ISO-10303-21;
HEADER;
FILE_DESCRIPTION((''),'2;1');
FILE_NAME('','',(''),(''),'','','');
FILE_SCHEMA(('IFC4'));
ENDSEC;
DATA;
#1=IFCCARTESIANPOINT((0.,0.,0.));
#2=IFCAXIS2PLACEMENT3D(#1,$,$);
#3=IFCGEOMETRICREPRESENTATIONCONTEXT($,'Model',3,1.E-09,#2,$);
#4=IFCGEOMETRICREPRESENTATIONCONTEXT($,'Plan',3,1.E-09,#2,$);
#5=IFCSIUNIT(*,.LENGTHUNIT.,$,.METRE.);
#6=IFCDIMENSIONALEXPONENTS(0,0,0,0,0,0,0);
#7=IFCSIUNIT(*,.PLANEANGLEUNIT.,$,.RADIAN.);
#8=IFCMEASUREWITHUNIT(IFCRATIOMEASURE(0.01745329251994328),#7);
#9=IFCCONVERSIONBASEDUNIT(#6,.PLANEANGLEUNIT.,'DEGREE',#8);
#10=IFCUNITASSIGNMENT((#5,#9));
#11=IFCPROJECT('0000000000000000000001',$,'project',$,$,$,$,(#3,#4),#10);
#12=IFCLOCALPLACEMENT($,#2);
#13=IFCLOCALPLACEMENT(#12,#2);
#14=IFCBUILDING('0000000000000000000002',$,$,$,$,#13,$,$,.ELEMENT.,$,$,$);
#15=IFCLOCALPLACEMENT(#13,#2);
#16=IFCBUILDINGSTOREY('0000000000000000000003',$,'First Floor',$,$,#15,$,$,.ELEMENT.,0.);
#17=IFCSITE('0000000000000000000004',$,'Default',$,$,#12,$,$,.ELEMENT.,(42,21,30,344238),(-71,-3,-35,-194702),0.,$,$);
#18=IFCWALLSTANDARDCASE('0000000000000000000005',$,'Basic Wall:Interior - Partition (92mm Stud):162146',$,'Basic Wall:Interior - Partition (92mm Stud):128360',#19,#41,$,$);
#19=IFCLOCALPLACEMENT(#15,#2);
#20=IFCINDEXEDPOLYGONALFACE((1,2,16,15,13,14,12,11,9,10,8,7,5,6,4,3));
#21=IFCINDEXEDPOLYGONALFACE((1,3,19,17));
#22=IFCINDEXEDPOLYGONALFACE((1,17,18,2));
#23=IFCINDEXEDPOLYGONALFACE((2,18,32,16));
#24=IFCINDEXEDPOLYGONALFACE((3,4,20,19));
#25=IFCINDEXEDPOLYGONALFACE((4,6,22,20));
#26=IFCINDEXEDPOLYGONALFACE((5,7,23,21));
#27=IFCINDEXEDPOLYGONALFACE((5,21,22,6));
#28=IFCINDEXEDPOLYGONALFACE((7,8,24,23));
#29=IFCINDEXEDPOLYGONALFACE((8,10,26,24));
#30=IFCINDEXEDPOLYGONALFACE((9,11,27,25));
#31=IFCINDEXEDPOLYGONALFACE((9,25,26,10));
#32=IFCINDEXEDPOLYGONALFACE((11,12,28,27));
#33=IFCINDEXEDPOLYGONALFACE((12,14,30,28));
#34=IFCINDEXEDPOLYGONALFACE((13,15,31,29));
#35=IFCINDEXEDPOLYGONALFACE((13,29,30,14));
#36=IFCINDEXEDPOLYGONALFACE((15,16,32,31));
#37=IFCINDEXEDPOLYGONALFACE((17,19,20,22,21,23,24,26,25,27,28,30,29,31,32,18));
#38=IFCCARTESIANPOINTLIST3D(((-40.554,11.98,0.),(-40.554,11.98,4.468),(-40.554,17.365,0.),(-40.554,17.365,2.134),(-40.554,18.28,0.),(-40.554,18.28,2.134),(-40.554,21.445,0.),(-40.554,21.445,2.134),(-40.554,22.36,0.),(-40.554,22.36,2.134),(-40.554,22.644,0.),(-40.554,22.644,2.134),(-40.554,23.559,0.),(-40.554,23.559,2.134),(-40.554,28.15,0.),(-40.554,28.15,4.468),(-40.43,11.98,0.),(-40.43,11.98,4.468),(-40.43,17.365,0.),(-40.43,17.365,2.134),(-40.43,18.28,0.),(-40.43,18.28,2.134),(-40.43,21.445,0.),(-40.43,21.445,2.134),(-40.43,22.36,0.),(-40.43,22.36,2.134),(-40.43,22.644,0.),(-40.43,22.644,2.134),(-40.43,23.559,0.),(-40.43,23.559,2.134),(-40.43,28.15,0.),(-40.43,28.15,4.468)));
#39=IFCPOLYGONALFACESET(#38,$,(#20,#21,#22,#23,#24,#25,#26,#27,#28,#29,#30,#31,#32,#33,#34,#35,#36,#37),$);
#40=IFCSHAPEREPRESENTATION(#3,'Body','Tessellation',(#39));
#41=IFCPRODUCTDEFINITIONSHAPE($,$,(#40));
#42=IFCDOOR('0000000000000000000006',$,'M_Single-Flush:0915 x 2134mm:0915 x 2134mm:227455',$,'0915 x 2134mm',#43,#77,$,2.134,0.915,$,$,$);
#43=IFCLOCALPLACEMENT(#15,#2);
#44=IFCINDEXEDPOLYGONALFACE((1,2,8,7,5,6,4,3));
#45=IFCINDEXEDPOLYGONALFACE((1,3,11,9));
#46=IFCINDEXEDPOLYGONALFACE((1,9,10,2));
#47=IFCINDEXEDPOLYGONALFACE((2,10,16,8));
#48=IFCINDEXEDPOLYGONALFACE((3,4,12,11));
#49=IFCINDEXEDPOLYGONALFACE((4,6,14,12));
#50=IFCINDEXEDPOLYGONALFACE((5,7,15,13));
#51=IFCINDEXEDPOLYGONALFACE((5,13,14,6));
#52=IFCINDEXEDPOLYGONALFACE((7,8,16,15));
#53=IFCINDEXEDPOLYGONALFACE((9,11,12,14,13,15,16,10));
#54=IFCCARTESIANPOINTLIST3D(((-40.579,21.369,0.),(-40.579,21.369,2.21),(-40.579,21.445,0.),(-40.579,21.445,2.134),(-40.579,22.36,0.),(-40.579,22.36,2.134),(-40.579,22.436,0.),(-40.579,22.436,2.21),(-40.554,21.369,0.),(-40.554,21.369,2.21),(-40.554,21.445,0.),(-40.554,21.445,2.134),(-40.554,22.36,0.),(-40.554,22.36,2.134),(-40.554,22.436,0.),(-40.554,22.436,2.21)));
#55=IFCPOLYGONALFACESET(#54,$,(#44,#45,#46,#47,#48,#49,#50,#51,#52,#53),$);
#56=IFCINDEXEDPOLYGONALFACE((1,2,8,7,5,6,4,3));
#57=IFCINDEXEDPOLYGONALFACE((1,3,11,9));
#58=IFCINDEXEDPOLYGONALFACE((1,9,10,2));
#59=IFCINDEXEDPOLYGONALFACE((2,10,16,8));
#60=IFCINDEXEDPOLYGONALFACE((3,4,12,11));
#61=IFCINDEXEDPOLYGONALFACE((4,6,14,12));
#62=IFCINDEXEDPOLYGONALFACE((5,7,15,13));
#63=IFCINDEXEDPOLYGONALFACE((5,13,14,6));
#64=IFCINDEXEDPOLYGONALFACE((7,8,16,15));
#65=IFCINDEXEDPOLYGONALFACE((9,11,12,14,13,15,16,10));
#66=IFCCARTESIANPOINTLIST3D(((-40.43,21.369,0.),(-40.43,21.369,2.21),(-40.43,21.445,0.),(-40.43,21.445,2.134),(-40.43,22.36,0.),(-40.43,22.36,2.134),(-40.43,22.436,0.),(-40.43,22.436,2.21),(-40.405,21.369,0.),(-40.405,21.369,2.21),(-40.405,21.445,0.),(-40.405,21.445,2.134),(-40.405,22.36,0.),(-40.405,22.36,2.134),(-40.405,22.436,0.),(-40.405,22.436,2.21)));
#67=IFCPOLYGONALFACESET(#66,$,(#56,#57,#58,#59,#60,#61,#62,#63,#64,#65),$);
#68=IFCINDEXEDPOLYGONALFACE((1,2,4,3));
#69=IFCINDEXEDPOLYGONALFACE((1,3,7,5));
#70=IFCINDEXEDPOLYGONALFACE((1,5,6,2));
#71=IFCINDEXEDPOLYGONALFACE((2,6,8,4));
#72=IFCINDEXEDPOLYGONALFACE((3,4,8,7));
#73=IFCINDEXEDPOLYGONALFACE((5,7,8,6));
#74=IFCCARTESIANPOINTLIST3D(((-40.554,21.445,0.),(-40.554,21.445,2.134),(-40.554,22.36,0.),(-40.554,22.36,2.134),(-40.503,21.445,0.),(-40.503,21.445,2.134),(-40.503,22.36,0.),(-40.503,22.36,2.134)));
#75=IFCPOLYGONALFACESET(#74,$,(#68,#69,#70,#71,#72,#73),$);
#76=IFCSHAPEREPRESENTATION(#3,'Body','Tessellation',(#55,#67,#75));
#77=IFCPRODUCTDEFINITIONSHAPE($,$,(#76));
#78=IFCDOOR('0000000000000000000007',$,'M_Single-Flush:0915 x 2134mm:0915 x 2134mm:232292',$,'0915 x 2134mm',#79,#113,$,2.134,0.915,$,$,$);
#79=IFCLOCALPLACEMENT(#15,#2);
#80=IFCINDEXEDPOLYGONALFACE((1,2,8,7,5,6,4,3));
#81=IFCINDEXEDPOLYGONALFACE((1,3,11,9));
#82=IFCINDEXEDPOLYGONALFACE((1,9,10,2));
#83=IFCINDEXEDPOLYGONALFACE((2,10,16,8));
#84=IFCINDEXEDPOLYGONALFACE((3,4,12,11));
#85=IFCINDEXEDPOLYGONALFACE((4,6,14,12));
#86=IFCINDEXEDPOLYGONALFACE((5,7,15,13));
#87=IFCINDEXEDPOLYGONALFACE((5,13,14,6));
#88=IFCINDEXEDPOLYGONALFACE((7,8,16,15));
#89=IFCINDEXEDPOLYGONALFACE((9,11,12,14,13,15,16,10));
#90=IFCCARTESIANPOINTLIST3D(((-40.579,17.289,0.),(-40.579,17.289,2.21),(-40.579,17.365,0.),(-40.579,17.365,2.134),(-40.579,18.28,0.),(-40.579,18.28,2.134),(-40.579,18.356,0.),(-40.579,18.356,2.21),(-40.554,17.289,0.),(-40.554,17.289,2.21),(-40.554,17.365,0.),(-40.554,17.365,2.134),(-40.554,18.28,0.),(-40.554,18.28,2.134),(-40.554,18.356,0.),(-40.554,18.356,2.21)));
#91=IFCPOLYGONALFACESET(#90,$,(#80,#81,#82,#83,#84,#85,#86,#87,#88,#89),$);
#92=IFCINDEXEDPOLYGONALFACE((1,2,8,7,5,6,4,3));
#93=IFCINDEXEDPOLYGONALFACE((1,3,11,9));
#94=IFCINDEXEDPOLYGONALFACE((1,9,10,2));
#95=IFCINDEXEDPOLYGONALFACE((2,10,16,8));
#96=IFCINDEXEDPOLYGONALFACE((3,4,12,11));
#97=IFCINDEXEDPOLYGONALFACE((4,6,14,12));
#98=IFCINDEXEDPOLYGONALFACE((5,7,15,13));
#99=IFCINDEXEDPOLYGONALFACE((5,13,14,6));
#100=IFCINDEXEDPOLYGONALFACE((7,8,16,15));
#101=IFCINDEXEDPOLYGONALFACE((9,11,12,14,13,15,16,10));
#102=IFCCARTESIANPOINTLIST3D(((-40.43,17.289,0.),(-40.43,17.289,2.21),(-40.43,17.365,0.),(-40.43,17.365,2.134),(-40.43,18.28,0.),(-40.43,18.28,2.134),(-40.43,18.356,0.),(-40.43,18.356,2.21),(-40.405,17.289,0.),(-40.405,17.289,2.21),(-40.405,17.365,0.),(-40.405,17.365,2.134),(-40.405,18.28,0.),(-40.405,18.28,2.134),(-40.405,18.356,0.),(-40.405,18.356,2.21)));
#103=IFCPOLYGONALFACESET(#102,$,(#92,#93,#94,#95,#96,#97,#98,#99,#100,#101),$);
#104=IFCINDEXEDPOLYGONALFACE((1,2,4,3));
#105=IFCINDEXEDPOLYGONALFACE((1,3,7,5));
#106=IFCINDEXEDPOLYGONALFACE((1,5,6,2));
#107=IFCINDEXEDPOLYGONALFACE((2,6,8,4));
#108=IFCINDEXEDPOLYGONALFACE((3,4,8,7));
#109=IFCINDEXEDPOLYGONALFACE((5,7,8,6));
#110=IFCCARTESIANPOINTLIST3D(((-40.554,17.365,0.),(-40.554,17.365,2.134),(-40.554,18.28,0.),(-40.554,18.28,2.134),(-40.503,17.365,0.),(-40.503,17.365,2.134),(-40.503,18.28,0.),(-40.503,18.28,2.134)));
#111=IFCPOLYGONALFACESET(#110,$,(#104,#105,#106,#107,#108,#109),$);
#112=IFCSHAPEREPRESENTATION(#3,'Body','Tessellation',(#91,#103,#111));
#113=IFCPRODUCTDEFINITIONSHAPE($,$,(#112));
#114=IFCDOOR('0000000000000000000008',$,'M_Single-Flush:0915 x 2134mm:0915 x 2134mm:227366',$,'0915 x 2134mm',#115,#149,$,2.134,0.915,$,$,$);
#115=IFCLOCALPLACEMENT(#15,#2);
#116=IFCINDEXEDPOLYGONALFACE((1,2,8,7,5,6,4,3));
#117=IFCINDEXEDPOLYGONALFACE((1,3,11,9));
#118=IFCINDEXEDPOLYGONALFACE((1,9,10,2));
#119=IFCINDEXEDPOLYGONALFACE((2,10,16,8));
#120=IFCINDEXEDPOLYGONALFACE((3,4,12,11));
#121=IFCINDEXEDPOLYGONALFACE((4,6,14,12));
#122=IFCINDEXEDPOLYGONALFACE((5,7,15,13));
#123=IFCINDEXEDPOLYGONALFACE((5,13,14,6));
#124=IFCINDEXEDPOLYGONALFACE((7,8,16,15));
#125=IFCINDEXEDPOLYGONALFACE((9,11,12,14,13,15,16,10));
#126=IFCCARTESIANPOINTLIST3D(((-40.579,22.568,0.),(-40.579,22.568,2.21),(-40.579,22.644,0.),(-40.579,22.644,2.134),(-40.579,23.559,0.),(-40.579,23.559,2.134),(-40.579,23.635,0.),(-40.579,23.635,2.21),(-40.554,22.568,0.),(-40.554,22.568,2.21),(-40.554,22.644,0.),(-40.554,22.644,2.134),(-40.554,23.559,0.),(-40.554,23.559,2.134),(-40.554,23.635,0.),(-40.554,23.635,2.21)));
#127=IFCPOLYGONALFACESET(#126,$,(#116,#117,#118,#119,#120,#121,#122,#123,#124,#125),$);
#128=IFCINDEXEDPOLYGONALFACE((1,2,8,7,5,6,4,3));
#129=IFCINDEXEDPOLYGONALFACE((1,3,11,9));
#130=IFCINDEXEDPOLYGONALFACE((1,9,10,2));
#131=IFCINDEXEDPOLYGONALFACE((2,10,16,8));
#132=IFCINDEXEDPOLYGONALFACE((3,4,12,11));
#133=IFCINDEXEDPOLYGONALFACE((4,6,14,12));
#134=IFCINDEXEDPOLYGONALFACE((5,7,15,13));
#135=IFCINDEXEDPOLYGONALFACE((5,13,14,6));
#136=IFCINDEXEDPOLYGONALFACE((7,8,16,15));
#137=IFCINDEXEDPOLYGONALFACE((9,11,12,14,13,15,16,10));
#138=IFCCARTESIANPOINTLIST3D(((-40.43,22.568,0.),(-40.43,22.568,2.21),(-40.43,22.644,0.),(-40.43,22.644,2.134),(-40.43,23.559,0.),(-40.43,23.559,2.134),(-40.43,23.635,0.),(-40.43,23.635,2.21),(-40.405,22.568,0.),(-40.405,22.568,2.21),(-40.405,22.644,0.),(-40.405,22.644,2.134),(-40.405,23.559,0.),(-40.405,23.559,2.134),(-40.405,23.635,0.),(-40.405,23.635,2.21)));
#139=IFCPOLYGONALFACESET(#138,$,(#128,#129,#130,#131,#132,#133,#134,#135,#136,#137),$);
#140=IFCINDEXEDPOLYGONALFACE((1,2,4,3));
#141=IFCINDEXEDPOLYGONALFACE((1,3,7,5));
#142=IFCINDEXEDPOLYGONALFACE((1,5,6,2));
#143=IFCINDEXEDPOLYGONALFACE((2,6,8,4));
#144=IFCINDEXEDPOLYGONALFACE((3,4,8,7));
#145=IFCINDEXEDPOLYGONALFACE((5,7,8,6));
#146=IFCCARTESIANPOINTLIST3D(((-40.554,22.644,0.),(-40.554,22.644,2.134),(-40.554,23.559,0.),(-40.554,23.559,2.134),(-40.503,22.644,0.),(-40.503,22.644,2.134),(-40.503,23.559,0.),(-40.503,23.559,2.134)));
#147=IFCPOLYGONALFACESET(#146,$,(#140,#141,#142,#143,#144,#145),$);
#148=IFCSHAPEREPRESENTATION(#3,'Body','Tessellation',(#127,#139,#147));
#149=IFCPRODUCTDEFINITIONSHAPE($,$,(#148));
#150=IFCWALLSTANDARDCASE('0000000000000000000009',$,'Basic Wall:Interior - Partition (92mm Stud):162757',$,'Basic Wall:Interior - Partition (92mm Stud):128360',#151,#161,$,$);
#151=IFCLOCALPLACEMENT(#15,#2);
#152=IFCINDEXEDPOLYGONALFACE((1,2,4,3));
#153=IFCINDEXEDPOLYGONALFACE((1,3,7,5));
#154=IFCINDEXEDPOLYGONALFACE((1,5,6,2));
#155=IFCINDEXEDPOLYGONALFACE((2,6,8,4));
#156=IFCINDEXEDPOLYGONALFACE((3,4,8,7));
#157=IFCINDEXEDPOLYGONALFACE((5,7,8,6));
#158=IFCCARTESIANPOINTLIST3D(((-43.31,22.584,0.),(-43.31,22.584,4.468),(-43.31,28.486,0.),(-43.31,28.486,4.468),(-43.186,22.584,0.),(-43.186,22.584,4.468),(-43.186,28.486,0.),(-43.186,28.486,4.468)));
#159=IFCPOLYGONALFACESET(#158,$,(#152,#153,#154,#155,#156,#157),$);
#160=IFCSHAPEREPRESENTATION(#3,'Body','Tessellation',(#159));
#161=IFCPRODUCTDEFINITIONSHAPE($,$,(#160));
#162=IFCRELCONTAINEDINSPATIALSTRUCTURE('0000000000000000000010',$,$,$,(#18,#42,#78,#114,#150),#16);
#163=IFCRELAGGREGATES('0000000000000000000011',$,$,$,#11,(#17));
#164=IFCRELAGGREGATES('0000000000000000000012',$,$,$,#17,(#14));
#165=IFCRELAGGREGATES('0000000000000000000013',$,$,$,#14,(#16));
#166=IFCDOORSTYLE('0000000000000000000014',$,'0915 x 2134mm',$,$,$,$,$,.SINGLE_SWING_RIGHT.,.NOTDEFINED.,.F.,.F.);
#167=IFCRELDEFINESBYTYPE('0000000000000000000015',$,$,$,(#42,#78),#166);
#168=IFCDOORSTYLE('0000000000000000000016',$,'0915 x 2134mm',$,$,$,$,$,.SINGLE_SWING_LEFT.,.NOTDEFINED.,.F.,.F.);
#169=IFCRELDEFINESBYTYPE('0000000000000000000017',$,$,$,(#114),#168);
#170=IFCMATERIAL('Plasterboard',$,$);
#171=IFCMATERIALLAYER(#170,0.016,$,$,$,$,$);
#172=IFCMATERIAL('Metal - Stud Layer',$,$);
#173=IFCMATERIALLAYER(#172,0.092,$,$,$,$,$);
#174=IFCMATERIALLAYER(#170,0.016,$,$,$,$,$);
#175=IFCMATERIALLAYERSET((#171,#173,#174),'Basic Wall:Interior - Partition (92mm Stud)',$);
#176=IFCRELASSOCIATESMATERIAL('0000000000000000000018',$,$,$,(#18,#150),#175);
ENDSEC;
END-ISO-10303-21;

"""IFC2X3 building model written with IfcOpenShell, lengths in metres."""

from ifc_helpers import new_model, entity, si_unit, converted_unit, frame, frame_2d, origin, origin_2d_with_axis, place, context, project, spatial, polyline, rectangle, outline, extrude, source, transform, mapped, material, layer, layer_set, layer_usage, type_object, type_shapes, element, fill, save


model = new_model("IFC2X3")

# Units and contexts
model_context = context("Model", 3, precision=1e-09, world=origin())
plan_context = context("Plan", 3, precision=1e-09, world=origin())
ifc_project = project(units=[si_unit("LENGTHUNIT", "METRE"), converted_unit("PLANEANGLEUNIT", "DEGREE", entity("IfcRatioMeasure", 0.01745329251994328), si_unit("PLANEANGLEUNIT", "RADIAN"), dimensions=[0, 0, 0, 0, 0, 0, 0])], contexts=[model_context, plan_context])

# Site, building, storey
site_placement = place(None, origin())
site = spatial("IfcSite", under=ifc_project, at=site_placement, Name="Default", CompositionType="ELEMENT", RefLatitude=(42, 21, 30, 344238), RefLongitude=(-71, -3, -35, -194702), RefElevation=0.0)
building_placement = place(site_placement, origin())
building = spatial("IfcBuilding", under=site, at=building_placement, CompositionType="ELEMENT")
storey_placement = place(building_placement, origin())
storey = spatial("IfcBuildingStorey", under=building, at=storey_placement, Name="First Floor", CompositionType="ELEMENT", Elevation=0.0)

# Wall, openings, doors
ifc_material_1 = material(Name="Plasterboard")
ifc_layer_1 = layer(ifc_material_1, 0.016)
ifc_material_2 = material(Name="Metal - Stud Layer")
ifc_layer_2 = layer(ifc_material_2, 0.092)
ifc_layer_3 = layer(ifc_material_1, 0.016)
ifc_layer_set_1 = layer_set([ifc_layer_1, ifc_layer_2, ifc_layer_3], Name="Basic Wall:Interior - Partition (92mm Stud)")
ifc_layer_usage_1 = layer_usage(ifc_layer_set_1, "AXIS2", "NEGATIVE", 0.062)
wall_1_placement = place(storey_placement, frame((-40.492, 28.15, 0.0), z_axis=(0.0, 0.0, 1.0), x_axis=(0.0, -1.0, 0.0)))
wall_1 = element("IfcWallStandardCase", 1, at=wall_1_placement, inside=storey, material=ifc_layer_usage_1, Name="Basic Wall:Interior - Partition (92mm Stud):162146", ObjectType="Basic Wall:Interior - Partition (92mm Stud):128360", context=model_context, shape_type="SweptSolid", body=[
    extrude(rectangle(XDim=16.17, YDim=0.124, at=frame_2d((8.085, 0.0), x_axis=(-1.0, 0.0))), origin(), (0.0, 0.0, 1.0), 4.468),
])
opening_1_placement = place(wall_1_placement, frame((6.705, 0.062, 0.0)))
opening_1 = element("IfcOpeningElement", 2, at=opening_1_placement, cuts=wall_1, ObjectType="Opening", context=model_context, shape_type="SweptSolid", body=[
    extrude(rectangle(XDim=0.915, YDim=2.134, at=frame_2d((1.067, 0.4575), x_axis=(0.0, 1.0))), frame((0.0, 0.0, 0.0), z_axis=(0.0, -1.0, 0.0), x_axis=(0.0, 0.0, 1.0)), (0.0, 0.0, 1.0), 0.124),
])
opening_2_placement = place(wall_1_placement, frame((5.506, 0.062, 0.0)))
opening_2 = element("IfcOpeningElement", 3, at=opening_2_placement, cuts=wall_1, ObjectType="Opening", context=model_context, shape_type="SweptSolid", body=[
    extrude(rectangle(XDim=0.915, YDim=2.134, at=frame_2d((1.067, 0.4575), x_axis=(0.0, -1.0))), frame((0.0, 0.0, 0.0), z_axis=(0.0, -1.0, 0.0), x_axis=(0.0, 0.0, 1.0)), (0.0, 0.0, 1.0), 0.124),
])
opening_3_placement = place(wall_1_placement, frame((10.785, 0.062, 0.0)))
opening_3 = element("IfcOpeningElement", 4, at=opening_3_placement, cuts=wall_1, ObjectType="Opening", context=model_context, shape_type="SweptSolid", body=[
    extrude(rectangle(XDim=0.915, YDim=2.134, at=frame_2d((1.067, 0.4575), x_axis=(0.0, 1.0))), frame((0.0, 0.0, 0.0), z_axis=(0.0, -1.0, 0.0), x_axis=(0.0, 0.0, 1.0)), (0.0, 0.0, 1.0), 0.124),
])
door_style_1 = type_object("IfcDoorStyle", Name="0915 x 2134mm", ConstructionType="NOTDEFINED", OperationType="SINGLE_SWING_RIGHT", ParameterTakesPrecedence=False, Sizeable=False)
shared_shape_1 = source(origin(), model_context, "Body", "SweptSolid", [
    extrude(outline(polyline([(-0.5335, -1.124), (0.5335, -1.124), (0.5335, 1.086), (0.4575, 1.086), (0.4575, -1.048), (-0.4575, -1.048), (-0.4575, 1.086), (-0.5335, 1.086), (-0.5335, -1.124)])), frame((0.4575, 0.124, 1.086), z_axis=(0.0, 1.0, 0.0), x_axis=(1.0, 0.0, 0.0)), (0.0, 0.0, 1.0), 0.025),
    extrude(outline(polyline([(-1.124, -0.5335), (1.086, -0.5335), (1.086, -0.4575), (-1.048, -0.4575), (-1.048, 0.4575), (1.086, 0.4575), (1.086, 0.5335), (-1.124, 0.5335), (-1.124, -0.5335)])), frame((0.4575, -0.025, 1.086), z_axis=(0.0, 1.0, 0.0), x_axis=(0.0, 0.0, -1.0)), (0.0, 0.0, 1.0), 0.025),
    extrude(rectangle(XDim=0.051, YDim=0.915, at=origin_2d_with_axis()), frame((0.4575, 0.0985, 0.0), z_axis=(0.0, 0.0, 1.0), x_axis=(0.0, 1.0, 0.0)), (0.0, 0.0, 1.0), 2.134),
])
type_shapes(door_style_1, [shared_shape_1])
door_1_placement = place(opening_1_placement, frame((0.0, 0.0, 0.0), z_axis=(0.0, 0.0, 1.0), x_axis=(-1.0, 0.0, 0.0)))
door_1 = element("IfcDoor", 5, at=door_1_placement, inside=storey, type_object=door_style_1, Name="M_Single-Flush:0915 x 2134mm:0915 x 2134mm:227455", ObjectType="0915 x 2134mm", OverallHeight=2.134, OverallWidth=0.915, context=model_context, shape_type="MappedRepresentation", body=[
    mapped(shared_shape_1, transform((0.0, 0.0, 0.0), scale=1.0)),
])
fill(opening_1, door_1)
door_2_placement = place(opening_3_placement, frame((0.0, 0.0, 0.0), z_axis=(0.0, 0.0, 1.0), x_axis=(-1.0, 0.0, 0.0)))
door_2 = element("IfcDoor", 6, at=door_2_placement, inside=storey, type_object=door_style_1, Name="M_Single-Flush:0915 x 2134mm:0915 x 2134mm:232292", ObjectType="0915 x 2134mm", OverallHeight=2.134, OverallWidth=0.915, context=model_context, shape_type="MappedRepresentation", body=[
    mapped(shared_shape_1, transform((0.0, 0.0, 0.0), scale=1.0)),
])
fill(opening_3, door_2)
door_style_2 = type_object("IfcDoorStyle", Name="0915 x 2134mm", ConstructionType="NOTDEFINED", OperationType="SINGLE_SWING_LEFT", ParameterTakesPrecedence=False, Sizeable=False)
shared_shape_2 = source(origin(), model_context, "Body", "SweptSolid", [
    extrude(outline(polyline([(-0.5335, -1.124), (0.5335, -1.124), (0.5335, 1.086), (0.4575, 1.086), (0.4575, -1.048), (-0.4575, -1.048), (-0.4575, 1.086), (-0.5335, 1.086), (-0.5335, -1.124)])), frame((0.4575, 0.149, 1.086), z_axis=(0.0, -1.0, 0.0), x_axis=(-1.0, 0.0, 0.0)), (0.0, 0.0, 1.0), 0.025),
    extrude(outline(polyline([(-1.124, -0.5335), (1.086, -0.5335), (1.086, -0.4575), (-1.048, -0.4575), (-1.048, 0.4575), (1.086, 0.4575), (1.086, 0.5335), (-1.124, 0.5335), (-1.124, -0.5335)])), frame((0.4575, 0.0, 1.086), z_axis=(0.0, -1.0, 0.0), x_axis=(0.0, 0.0, -1.0)), (0.0, 0.0, 1.0), 0.025),
    extrude(rectangle(XDim=0.915, YDim=0.051, at=origin_2d_with_axis()), frame((0.4575, 0.0985, 0.0)), (0.0, 0.0, 1.0), 2.134),
])
type_shapes(door_style_2, [shared_shape_2])
door_3_placement = place(opening_2_placement, frame((0.0, 0.0, 0.0), z_axis=(0.0, 0.0, 1.0), x_axis=(-1.0, 0.0, 0.0)))
door_3 = element("IfcDoor", 7, at=door_3_placement, inside=storey, type_object=door_style_2, Name="M_Single-Flush:0915 x 2134mm:0915 x 2134mm:227366", ObjectType="0915 x 2134mm", OverallHeight=2.134, OverallWidth=0.915, context=model_context, shape_type="MappedRepresentation", body=[
    mapped(shared_shape_2, transform((0.0, 0.0, 0.0), scale=1.0)),
])
fill(opening_2, door_3)

# Wall
wall_2_placement = place(storey_placement, frame((-43.248, 22.584, 0.0), z_axis=(0.0, 0.0, 1.0), x_axis=(0.0, 1.0, 0.0)))
element("IfcWallStandardCase", 8, at=wall_2_placement, inside=storey, material=ifc_layer_usage_1, Name="Basic Wall:Interior - Partition (92mm Stud):162757", ObjectType="Basic Wall:Interior - Partition (92mm Stud):128360", context=model_context, shape_type="SweptSolid", body=[
    extrude(rectangle(XDim=5.902, YDim=0.124, at=frame_2d((2.951, 0.0), x_axis=(-1.0, 0.0))), origin(), (0.0, 0.0, 1.0), 4.468),
])

save(model, "model.ifc")
